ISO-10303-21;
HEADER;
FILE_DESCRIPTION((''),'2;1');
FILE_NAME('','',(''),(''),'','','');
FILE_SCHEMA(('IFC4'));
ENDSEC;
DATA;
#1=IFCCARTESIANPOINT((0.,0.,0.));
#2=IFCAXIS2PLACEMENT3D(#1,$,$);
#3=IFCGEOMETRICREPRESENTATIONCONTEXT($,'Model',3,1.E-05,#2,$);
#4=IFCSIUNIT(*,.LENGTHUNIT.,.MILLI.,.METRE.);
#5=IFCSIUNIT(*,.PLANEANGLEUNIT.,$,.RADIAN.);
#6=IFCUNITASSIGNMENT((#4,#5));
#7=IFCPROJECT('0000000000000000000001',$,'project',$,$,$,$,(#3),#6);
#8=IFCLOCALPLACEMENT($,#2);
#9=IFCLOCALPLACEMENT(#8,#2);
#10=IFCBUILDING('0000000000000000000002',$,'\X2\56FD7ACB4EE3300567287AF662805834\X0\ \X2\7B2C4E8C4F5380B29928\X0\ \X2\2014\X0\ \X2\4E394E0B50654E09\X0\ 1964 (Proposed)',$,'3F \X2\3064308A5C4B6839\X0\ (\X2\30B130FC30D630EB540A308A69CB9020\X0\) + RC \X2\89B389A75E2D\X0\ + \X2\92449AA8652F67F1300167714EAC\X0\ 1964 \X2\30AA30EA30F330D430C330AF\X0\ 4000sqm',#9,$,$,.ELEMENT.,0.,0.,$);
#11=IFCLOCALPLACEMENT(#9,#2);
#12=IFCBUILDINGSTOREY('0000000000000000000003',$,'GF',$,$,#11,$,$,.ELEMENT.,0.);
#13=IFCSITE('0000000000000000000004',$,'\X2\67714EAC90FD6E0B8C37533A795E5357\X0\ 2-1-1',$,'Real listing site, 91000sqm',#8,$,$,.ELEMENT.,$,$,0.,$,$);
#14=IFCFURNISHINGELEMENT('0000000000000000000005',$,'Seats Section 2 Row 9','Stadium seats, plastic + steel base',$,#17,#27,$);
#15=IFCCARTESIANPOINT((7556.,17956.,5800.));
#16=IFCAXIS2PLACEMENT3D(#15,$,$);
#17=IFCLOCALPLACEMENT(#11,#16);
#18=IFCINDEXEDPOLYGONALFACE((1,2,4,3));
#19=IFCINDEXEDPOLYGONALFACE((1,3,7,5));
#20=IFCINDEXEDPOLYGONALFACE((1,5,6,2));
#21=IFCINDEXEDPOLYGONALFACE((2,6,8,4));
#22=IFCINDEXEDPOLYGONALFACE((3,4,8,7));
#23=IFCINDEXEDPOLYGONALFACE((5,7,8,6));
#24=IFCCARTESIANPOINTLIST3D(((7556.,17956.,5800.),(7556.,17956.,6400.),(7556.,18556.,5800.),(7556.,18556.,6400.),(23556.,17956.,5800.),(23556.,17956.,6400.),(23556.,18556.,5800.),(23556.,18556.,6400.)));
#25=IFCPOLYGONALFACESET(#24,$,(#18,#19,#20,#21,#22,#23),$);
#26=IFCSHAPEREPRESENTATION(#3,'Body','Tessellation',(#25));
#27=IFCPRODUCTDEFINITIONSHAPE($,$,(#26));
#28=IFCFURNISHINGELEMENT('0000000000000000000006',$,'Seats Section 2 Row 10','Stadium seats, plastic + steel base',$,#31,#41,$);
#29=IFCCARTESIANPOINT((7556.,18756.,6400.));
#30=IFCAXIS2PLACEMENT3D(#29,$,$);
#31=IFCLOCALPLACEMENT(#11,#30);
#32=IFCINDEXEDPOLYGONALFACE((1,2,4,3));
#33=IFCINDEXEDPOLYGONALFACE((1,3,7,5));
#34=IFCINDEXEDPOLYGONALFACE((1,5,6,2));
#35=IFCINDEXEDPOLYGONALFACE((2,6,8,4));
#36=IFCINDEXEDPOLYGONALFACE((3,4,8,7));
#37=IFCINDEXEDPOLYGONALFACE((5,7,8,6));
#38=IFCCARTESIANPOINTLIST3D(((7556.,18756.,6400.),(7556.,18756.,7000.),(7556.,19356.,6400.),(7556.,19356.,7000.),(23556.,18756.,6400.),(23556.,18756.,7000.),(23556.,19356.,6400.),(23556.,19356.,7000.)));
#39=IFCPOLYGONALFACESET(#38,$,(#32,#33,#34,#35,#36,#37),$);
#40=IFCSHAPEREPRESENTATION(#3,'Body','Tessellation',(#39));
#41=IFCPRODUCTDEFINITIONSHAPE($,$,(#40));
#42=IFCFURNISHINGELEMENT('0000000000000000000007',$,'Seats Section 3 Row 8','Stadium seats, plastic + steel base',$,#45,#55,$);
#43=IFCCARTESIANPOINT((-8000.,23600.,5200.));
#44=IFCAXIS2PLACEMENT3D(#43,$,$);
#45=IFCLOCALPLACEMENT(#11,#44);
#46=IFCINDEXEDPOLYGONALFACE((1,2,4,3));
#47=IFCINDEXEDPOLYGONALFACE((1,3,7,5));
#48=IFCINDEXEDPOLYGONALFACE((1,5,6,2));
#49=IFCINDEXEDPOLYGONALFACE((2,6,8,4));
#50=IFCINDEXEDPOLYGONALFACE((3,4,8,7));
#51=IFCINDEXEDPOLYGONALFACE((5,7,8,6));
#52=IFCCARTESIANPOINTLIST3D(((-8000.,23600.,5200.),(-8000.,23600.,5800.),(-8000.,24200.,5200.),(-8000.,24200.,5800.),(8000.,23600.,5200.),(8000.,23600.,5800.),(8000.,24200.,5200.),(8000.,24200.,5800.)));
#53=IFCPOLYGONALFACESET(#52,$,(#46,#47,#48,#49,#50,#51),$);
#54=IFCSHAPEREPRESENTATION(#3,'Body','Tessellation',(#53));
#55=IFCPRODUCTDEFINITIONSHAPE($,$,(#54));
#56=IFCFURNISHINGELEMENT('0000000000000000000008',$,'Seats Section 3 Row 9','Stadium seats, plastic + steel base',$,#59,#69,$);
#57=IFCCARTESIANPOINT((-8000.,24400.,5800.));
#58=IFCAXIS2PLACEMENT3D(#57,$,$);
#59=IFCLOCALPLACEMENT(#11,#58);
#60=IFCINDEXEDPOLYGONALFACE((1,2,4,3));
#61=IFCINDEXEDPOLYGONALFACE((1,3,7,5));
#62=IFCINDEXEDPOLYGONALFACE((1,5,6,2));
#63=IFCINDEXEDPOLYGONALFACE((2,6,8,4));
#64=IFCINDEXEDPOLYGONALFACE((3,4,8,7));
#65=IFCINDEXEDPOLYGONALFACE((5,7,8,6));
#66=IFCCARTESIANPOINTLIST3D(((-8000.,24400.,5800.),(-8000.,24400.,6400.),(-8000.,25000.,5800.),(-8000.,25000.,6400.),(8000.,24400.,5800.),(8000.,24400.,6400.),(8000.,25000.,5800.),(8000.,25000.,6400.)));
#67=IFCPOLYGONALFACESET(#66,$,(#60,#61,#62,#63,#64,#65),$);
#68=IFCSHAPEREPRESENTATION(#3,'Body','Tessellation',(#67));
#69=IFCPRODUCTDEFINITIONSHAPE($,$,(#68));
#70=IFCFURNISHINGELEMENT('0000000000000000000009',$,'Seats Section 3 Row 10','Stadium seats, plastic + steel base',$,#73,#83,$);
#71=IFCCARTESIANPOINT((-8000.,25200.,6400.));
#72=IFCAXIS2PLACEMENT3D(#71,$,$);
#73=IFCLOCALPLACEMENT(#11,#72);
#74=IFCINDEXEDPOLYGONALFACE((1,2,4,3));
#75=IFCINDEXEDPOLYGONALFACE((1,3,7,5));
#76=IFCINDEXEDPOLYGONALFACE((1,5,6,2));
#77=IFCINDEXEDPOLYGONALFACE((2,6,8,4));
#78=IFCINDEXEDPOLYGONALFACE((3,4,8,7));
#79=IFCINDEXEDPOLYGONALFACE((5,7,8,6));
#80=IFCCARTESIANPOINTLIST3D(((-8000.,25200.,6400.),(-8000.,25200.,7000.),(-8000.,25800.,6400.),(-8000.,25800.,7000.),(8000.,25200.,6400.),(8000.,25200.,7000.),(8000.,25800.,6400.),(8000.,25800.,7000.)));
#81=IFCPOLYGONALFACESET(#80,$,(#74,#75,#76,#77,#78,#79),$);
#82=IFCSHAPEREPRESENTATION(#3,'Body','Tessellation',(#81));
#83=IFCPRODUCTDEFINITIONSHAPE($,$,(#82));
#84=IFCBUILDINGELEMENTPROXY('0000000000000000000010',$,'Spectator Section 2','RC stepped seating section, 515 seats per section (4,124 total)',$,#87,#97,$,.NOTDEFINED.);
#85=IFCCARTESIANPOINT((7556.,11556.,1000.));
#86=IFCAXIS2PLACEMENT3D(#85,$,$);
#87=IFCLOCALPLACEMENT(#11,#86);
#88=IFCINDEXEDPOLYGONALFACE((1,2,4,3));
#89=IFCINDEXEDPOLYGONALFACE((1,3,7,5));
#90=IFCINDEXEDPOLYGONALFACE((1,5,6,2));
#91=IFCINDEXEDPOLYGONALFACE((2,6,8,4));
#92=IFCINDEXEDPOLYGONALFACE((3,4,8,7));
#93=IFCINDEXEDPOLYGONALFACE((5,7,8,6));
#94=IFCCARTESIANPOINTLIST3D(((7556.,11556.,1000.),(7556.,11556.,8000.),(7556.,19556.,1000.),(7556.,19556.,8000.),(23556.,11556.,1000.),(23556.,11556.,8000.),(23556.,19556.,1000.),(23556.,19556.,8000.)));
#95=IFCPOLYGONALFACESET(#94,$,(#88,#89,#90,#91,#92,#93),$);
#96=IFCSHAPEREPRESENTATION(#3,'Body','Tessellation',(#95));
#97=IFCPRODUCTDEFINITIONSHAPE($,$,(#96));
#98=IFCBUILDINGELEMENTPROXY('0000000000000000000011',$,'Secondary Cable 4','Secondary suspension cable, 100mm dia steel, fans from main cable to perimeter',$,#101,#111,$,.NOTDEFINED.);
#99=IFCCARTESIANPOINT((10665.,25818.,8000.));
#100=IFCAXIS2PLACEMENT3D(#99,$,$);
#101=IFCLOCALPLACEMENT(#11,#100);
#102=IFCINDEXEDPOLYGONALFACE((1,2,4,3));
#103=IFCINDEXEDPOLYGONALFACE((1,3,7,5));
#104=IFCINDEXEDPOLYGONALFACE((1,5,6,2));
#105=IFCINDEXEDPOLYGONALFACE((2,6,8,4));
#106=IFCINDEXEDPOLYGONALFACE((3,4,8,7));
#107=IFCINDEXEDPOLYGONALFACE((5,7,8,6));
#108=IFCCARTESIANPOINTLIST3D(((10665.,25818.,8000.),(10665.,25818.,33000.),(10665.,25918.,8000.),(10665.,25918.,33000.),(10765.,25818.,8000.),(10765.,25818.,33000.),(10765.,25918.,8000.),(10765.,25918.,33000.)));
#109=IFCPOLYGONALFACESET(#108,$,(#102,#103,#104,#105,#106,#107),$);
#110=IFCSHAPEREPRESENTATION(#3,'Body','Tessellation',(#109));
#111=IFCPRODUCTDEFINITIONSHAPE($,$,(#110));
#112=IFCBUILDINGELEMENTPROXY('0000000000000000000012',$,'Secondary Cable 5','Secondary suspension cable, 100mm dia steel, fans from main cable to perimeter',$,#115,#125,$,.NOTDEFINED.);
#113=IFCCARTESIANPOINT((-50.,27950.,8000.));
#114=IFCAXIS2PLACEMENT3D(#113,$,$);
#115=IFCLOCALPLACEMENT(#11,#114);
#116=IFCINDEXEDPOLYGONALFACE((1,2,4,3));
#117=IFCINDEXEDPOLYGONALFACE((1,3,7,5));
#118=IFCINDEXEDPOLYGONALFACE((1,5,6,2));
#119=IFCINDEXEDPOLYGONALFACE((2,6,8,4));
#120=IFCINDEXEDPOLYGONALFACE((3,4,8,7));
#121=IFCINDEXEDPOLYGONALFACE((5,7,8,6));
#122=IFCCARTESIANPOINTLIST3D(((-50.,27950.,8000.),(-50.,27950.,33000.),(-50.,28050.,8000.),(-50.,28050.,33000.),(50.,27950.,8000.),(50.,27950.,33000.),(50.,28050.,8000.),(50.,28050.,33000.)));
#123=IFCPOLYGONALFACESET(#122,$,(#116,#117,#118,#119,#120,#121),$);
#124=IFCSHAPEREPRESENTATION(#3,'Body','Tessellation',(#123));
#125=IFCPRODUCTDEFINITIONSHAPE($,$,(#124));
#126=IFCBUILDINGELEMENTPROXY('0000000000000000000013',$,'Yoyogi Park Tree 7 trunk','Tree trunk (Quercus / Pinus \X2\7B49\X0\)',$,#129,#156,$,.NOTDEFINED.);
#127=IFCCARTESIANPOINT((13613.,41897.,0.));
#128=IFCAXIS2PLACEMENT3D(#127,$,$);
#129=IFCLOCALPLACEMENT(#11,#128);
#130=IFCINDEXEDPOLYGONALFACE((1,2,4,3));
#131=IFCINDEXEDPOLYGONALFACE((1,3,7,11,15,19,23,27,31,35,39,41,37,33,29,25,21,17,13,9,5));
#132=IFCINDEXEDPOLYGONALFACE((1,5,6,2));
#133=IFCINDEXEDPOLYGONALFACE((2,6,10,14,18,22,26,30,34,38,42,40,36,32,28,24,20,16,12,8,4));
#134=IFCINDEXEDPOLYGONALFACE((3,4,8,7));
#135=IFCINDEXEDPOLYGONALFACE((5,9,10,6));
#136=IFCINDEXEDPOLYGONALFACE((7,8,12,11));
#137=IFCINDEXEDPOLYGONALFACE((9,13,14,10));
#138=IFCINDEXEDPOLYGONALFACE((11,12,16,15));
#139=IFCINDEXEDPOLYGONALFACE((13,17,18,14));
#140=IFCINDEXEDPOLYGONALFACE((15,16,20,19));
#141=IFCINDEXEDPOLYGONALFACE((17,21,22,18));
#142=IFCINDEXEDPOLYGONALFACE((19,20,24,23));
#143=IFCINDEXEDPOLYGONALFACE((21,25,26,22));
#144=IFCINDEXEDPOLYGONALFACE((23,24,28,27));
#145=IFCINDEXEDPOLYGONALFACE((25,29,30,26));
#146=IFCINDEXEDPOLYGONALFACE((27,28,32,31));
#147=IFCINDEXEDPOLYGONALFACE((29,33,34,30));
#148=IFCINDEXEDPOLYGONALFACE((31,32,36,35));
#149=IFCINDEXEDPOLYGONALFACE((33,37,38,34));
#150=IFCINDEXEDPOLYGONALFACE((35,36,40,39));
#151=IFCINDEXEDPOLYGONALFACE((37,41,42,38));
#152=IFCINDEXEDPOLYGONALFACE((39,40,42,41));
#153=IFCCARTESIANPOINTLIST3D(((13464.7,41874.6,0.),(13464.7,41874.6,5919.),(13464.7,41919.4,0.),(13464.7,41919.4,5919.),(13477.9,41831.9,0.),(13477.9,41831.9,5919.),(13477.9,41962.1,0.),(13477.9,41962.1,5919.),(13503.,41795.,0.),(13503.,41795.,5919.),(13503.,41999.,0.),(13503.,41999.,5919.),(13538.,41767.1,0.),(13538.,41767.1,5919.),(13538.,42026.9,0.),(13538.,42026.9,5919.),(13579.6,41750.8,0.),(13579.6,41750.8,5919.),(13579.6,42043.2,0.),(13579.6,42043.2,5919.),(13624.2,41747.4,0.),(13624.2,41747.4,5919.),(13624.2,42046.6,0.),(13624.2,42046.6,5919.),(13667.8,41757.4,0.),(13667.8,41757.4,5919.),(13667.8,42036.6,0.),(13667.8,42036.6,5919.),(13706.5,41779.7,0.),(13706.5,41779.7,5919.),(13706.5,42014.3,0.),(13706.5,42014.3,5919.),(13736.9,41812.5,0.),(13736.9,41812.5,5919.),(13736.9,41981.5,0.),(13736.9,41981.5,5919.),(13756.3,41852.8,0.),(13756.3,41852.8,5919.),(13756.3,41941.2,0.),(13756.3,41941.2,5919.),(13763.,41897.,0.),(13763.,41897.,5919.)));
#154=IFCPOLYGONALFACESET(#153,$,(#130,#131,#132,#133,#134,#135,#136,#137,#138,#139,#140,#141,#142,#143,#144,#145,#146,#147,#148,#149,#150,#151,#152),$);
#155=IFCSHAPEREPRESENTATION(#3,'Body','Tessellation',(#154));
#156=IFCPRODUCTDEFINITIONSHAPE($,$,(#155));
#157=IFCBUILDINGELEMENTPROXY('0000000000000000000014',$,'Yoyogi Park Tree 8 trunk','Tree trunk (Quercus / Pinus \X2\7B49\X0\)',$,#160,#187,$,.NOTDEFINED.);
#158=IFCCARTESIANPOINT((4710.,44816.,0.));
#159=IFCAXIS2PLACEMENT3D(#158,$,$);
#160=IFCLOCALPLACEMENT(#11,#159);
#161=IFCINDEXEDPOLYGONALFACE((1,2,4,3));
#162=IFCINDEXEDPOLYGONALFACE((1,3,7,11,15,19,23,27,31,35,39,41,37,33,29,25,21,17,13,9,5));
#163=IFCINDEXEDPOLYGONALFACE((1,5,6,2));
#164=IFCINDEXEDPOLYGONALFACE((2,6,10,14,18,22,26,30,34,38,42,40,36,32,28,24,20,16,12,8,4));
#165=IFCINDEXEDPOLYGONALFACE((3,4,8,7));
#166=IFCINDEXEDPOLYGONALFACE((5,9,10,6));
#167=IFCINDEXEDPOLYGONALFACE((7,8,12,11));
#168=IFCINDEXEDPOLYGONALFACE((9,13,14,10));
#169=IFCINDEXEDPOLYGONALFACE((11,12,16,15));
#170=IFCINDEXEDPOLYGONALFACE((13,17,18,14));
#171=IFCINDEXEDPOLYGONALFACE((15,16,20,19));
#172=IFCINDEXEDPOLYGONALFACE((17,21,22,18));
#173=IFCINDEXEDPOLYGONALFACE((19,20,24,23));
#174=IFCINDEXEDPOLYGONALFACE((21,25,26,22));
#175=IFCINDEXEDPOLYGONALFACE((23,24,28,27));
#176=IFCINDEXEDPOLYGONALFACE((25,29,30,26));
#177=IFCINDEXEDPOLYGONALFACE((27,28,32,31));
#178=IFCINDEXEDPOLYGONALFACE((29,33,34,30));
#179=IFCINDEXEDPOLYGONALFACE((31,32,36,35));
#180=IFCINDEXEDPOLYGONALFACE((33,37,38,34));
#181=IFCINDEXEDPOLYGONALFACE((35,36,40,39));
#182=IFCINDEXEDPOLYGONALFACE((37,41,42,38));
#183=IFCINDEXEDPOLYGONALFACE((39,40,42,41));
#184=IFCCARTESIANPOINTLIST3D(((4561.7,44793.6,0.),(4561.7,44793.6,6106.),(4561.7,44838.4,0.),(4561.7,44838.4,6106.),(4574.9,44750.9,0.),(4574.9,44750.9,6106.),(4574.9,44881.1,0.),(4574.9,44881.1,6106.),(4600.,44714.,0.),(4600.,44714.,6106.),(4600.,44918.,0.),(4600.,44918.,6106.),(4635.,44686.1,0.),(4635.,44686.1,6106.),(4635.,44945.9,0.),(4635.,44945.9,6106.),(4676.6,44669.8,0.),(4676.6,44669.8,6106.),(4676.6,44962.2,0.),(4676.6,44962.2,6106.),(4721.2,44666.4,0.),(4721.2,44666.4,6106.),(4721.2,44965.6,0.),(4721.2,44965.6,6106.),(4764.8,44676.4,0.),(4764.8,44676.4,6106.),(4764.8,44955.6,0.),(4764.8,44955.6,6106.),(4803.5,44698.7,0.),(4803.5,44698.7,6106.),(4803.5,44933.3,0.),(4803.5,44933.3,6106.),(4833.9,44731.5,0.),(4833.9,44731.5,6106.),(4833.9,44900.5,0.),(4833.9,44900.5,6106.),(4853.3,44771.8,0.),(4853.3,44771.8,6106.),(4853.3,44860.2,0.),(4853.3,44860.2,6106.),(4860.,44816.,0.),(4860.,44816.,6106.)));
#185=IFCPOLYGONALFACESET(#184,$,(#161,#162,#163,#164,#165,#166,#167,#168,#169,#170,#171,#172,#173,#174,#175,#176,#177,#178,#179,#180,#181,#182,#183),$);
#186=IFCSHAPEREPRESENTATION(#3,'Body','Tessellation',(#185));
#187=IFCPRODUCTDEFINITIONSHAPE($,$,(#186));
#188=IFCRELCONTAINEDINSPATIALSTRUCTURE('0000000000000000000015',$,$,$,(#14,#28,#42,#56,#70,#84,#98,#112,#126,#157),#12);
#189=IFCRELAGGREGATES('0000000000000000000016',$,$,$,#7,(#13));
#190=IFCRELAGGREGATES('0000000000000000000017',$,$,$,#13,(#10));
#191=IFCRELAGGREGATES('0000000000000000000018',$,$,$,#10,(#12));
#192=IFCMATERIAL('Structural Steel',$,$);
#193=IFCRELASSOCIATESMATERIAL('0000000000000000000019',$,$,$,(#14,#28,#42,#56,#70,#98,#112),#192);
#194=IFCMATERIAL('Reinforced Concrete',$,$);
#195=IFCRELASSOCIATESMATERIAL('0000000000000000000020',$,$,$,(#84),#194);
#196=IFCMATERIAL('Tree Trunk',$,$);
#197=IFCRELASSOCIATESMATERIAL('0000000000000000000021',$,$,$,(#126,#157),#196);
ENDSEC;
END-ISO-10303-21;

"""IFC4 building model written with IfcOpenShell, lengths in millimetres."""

from ifc_helpers import new_model, si_unit, frame, frame_2d, origin, origin_2d, place, context, project, spatial, rectangle, circle, extrude, material, element, save


model = new_model("IFC4")

# Units and contexts
model_context = context("Model", 3, precision=1e-05, world=origin())
ifc_project = project(units=[si_unit("LENGTHUNIT", "METRE", prefix="MILLI"), si_unit("PLANEANGLEUNIT", "RADIAN")], contexts=[model_context])

# Site, building, storey
site_placement = place(None, origin())
site = spatial("IfcSite", under=ifc_project, at=site_placement, Name="東京都渋谷区神南 2-1-1", ObjectType="Real listing site, 91000sqm", CompositionType="ELEMENT", RefElevation=0.0)
building_placement = place(site_placement, origin())
building = spatial("IfcBuilding", under=site, at=building_placement, Name="国立代々木競技場 第二体育館 — 丹下健三 1964 (Proposed)", ObjectType="3F つり屋根 (ケーブル吊り構造) + RC 観覧席 + 鉄骨支柱、東京 1964 オリンピック 4000sqm", CompositionType="ELEMENT", ElevationOfRefHeight=0.0, ElevationOfTerrain=0.0)
storey_placement = place(building_placement, origin())
storey = spatial("IfcBuildingStorey", under=building, at=storey_placement, Name="GF", CompositionType="ELEMENT", Elevation=0.0)

# Shared definitions
ifc_material_1 = material(Name="Structural Steel")

# Furnishing elements
furnishing_1_placement = place(storey_placement, frame((7556.0, 17956.0, 5800.0)))
element("IfcFurnishingElement", 1, at=furnishing_1_placement, inside=storey, material=ifc_material_1, Name="Seats Section 2 Row 9", Description="Stadium seats, plastic + steel base", context=model_context, shape_type="SweptSolid", body=[
    extrude(rectangle(XDim=16000.0, YDim=600.0, at=frame_2d((8000.0, 300.0))), frame((7556.0, 17956.0, 5800.0)), (0.0, 0.0, 1.0), 600.0),
])
furnishing_2_placement = place(storey_placement, frame((7556.0, 18756.0, 6400.0)))
element("IfcFurnishingElement", 2, at=furnishing_2_placement, inside=storey, material=ifc_material_1, Name="Seats Section 2 Row 10", Description="Stadium seats, plastic + steel base", context=model_context, shape_type="SweptSolid", body=[
    extrude(rectangle(XDim=16000.0, YDim=600.0, at=frame_2d((8000.0, 300.0))), frame((7556.0, 18756.0, 6400.0)), (0.0, 0.0, 1.0), 600.0),
])
furnishing_3_placement = place(storey_placement, frame((-8000.0, 23600.0, 5200.0)))
element("IfcFurnishingElement", 3, at=furnishing_3_placement, inside=storey, material=ifc_material_1, Name="Seats Section 3 Row 8", Description="Stadium seats, plastic + steel base", context=model_context, shape_type="SweptSolid", body=[
    extrude(rectangle(XDim=16000.0, YDim=600.0, at=frame_2d((8000.0, 300.0))), frame((-8000.0, 23600.0, 5200.0)), (0.0, 0.0, 1.0), 600.0),
])
furnishing_4_placement = place(storey_placement, frame((-8000.0, 24400.0, 5800.0)))
element("IfcFurnishingElement", 4, at=furnishing_4_placement, inside=storey, material=ifc_material_1, Name="Seats Section 3 Row 9", Description="Stadium seats, plastic + steel base", context=model_context, shape_type="SweptSolid", body=[
    extrude(rectangle(XDim=16000.0, YDim=600.0, at=frame_2d((8000.0, 300.0))), frame((-8000.0, 24400.0, 5800.0)), (0.0, 0.0, 1.0), 600.0),
])
furnishing_5_placement = place(storey_placement, frame((-8000.0, 25200.0, 6400.0)))
element("IfcFurnishingElement", 5, at=furnishing_5_placement, inside=storey, material=ifc_material_1, Name="Seats Section 3 Row 10", Description="Stadium seats, plastic + steel base", context=model_context, shape_type="SweptSolid", body=[
    extrude(rectangle(XDim=16000.0, YDim=600.0, at=frame_2d((8000.0, 300.0))), frame((-8000.0, 25200.0, 6400.0)), (0.0, 0.0, 1.0), 600.0),
])

# Building element proxies
ifc_material_2 = material(Name="Reinforced Concrete")
proxy_1_placement = place(storey_placement, frame((7556.0, 11556.0, 1000.0)))
element("IfcBuildingElementProxy", 6, at=proxy_1_placement, inside=storey, material=ifc_material_2, Name="Spectator Section 2", Description="RC stepped seating section, 515 seats per section (4,124 total)", PredefinedType="NOTDEFINED", context=model_context, shape_type="SweptSolid", body=[
    extrude(rectangle(XDim=16000.0, YDim=8000.0, at=frame_2d((8000.0, 4000.0))), frame((7556.0, 11556.0, 1000.0)), (0.0, 0.0, 1.0), 7000.0),
])
proxy_2_placement = place(storey_placement, frame((10665.0, 25818.0, 8000.0)))
element("IfcBuildingElementProxy", 7, at=proxy_2_placement, inside=storey, material=ifc_material_1, Name="Secondary Cable 4", Description="Secondary suspension cable, 100mm dia steel, fans from main cable to perimeter", PredefinedType="NOTDEFINED", context=model_context, shape_type="SweptSolid", body=[
    extrude(rectangle(XDim=100.0, YDim=100.0, at=frame_2d((50.0, 50.0))), frame((10665.0, 25818.0, 8000.0)), (0.0, 0.0, 1.0), 25000.0),
])
proxy_3_placement = place(storey_placement, frame((-50.0, 27950.0, 8000.0)))
element("IfcBuildingElementProxy", 8, at=proxy_3_placement, inside=storey, material=ifc_material_1, Name="Secondary Cable 5", Description="Secondary suspension cable, 100mm dia steel, fans from main cable to perimeter", PredefinedType="NOTDEFINED", context=model_context, shape_type="SweptSolid", body=[
    extrude(rectangle(XDim=100.0, YDim=100.0, at=frame_2d((50.0, 50.0))), frame((-50.0, 27950.0, 8000.0)), (0.0, 0.0, 1.0), 25000.0),
])
ifc_material_3 = material(Name="Tree Trunk")
proxy_4_placement = place(storey_placement, frame((13613.0, 41897.0, 0.0)))
element("IfcBuildingElementProxy", 9, at=proxy_4_placement, inside=storey, material=ifc_material_3, Name="Yoyogi Park Tree 7 trunk", Description="Tree trunk (Quercus / Pinus 等)", PredefinedType="NOTDEFINED", context=model_context, shape_type="SweptSolid", body=[
    extrude(circle(Radius=150.0, at=origin_2d()), frame((13613.0, 41897.0, 0.0)), (0.0, 0.0, 1.0), 5919.0),
])
proxy_5_placement = place(storey_placement, frame((4710.0, 44816.0, 0.0)))
element("IfcBuildingElementProxy", 10, at=proxy_5_placement, inside=storey, material=ifc_material_3, Name="Yoyogi Park Tree 8 trunk", Description="Tree trunk (Quercus / Pinus 等)", PredefinedType="NOTDEFINED", context=model_context, shape_type="SweptSolid", body=[
    extrude(circle(Radius=150.0, at=origin_2d()), frame((4710.0, 44816.0, 0.0)), (0.0, 0.0, 1.0), 6106.0),
])

save(model, "model.ifc")
